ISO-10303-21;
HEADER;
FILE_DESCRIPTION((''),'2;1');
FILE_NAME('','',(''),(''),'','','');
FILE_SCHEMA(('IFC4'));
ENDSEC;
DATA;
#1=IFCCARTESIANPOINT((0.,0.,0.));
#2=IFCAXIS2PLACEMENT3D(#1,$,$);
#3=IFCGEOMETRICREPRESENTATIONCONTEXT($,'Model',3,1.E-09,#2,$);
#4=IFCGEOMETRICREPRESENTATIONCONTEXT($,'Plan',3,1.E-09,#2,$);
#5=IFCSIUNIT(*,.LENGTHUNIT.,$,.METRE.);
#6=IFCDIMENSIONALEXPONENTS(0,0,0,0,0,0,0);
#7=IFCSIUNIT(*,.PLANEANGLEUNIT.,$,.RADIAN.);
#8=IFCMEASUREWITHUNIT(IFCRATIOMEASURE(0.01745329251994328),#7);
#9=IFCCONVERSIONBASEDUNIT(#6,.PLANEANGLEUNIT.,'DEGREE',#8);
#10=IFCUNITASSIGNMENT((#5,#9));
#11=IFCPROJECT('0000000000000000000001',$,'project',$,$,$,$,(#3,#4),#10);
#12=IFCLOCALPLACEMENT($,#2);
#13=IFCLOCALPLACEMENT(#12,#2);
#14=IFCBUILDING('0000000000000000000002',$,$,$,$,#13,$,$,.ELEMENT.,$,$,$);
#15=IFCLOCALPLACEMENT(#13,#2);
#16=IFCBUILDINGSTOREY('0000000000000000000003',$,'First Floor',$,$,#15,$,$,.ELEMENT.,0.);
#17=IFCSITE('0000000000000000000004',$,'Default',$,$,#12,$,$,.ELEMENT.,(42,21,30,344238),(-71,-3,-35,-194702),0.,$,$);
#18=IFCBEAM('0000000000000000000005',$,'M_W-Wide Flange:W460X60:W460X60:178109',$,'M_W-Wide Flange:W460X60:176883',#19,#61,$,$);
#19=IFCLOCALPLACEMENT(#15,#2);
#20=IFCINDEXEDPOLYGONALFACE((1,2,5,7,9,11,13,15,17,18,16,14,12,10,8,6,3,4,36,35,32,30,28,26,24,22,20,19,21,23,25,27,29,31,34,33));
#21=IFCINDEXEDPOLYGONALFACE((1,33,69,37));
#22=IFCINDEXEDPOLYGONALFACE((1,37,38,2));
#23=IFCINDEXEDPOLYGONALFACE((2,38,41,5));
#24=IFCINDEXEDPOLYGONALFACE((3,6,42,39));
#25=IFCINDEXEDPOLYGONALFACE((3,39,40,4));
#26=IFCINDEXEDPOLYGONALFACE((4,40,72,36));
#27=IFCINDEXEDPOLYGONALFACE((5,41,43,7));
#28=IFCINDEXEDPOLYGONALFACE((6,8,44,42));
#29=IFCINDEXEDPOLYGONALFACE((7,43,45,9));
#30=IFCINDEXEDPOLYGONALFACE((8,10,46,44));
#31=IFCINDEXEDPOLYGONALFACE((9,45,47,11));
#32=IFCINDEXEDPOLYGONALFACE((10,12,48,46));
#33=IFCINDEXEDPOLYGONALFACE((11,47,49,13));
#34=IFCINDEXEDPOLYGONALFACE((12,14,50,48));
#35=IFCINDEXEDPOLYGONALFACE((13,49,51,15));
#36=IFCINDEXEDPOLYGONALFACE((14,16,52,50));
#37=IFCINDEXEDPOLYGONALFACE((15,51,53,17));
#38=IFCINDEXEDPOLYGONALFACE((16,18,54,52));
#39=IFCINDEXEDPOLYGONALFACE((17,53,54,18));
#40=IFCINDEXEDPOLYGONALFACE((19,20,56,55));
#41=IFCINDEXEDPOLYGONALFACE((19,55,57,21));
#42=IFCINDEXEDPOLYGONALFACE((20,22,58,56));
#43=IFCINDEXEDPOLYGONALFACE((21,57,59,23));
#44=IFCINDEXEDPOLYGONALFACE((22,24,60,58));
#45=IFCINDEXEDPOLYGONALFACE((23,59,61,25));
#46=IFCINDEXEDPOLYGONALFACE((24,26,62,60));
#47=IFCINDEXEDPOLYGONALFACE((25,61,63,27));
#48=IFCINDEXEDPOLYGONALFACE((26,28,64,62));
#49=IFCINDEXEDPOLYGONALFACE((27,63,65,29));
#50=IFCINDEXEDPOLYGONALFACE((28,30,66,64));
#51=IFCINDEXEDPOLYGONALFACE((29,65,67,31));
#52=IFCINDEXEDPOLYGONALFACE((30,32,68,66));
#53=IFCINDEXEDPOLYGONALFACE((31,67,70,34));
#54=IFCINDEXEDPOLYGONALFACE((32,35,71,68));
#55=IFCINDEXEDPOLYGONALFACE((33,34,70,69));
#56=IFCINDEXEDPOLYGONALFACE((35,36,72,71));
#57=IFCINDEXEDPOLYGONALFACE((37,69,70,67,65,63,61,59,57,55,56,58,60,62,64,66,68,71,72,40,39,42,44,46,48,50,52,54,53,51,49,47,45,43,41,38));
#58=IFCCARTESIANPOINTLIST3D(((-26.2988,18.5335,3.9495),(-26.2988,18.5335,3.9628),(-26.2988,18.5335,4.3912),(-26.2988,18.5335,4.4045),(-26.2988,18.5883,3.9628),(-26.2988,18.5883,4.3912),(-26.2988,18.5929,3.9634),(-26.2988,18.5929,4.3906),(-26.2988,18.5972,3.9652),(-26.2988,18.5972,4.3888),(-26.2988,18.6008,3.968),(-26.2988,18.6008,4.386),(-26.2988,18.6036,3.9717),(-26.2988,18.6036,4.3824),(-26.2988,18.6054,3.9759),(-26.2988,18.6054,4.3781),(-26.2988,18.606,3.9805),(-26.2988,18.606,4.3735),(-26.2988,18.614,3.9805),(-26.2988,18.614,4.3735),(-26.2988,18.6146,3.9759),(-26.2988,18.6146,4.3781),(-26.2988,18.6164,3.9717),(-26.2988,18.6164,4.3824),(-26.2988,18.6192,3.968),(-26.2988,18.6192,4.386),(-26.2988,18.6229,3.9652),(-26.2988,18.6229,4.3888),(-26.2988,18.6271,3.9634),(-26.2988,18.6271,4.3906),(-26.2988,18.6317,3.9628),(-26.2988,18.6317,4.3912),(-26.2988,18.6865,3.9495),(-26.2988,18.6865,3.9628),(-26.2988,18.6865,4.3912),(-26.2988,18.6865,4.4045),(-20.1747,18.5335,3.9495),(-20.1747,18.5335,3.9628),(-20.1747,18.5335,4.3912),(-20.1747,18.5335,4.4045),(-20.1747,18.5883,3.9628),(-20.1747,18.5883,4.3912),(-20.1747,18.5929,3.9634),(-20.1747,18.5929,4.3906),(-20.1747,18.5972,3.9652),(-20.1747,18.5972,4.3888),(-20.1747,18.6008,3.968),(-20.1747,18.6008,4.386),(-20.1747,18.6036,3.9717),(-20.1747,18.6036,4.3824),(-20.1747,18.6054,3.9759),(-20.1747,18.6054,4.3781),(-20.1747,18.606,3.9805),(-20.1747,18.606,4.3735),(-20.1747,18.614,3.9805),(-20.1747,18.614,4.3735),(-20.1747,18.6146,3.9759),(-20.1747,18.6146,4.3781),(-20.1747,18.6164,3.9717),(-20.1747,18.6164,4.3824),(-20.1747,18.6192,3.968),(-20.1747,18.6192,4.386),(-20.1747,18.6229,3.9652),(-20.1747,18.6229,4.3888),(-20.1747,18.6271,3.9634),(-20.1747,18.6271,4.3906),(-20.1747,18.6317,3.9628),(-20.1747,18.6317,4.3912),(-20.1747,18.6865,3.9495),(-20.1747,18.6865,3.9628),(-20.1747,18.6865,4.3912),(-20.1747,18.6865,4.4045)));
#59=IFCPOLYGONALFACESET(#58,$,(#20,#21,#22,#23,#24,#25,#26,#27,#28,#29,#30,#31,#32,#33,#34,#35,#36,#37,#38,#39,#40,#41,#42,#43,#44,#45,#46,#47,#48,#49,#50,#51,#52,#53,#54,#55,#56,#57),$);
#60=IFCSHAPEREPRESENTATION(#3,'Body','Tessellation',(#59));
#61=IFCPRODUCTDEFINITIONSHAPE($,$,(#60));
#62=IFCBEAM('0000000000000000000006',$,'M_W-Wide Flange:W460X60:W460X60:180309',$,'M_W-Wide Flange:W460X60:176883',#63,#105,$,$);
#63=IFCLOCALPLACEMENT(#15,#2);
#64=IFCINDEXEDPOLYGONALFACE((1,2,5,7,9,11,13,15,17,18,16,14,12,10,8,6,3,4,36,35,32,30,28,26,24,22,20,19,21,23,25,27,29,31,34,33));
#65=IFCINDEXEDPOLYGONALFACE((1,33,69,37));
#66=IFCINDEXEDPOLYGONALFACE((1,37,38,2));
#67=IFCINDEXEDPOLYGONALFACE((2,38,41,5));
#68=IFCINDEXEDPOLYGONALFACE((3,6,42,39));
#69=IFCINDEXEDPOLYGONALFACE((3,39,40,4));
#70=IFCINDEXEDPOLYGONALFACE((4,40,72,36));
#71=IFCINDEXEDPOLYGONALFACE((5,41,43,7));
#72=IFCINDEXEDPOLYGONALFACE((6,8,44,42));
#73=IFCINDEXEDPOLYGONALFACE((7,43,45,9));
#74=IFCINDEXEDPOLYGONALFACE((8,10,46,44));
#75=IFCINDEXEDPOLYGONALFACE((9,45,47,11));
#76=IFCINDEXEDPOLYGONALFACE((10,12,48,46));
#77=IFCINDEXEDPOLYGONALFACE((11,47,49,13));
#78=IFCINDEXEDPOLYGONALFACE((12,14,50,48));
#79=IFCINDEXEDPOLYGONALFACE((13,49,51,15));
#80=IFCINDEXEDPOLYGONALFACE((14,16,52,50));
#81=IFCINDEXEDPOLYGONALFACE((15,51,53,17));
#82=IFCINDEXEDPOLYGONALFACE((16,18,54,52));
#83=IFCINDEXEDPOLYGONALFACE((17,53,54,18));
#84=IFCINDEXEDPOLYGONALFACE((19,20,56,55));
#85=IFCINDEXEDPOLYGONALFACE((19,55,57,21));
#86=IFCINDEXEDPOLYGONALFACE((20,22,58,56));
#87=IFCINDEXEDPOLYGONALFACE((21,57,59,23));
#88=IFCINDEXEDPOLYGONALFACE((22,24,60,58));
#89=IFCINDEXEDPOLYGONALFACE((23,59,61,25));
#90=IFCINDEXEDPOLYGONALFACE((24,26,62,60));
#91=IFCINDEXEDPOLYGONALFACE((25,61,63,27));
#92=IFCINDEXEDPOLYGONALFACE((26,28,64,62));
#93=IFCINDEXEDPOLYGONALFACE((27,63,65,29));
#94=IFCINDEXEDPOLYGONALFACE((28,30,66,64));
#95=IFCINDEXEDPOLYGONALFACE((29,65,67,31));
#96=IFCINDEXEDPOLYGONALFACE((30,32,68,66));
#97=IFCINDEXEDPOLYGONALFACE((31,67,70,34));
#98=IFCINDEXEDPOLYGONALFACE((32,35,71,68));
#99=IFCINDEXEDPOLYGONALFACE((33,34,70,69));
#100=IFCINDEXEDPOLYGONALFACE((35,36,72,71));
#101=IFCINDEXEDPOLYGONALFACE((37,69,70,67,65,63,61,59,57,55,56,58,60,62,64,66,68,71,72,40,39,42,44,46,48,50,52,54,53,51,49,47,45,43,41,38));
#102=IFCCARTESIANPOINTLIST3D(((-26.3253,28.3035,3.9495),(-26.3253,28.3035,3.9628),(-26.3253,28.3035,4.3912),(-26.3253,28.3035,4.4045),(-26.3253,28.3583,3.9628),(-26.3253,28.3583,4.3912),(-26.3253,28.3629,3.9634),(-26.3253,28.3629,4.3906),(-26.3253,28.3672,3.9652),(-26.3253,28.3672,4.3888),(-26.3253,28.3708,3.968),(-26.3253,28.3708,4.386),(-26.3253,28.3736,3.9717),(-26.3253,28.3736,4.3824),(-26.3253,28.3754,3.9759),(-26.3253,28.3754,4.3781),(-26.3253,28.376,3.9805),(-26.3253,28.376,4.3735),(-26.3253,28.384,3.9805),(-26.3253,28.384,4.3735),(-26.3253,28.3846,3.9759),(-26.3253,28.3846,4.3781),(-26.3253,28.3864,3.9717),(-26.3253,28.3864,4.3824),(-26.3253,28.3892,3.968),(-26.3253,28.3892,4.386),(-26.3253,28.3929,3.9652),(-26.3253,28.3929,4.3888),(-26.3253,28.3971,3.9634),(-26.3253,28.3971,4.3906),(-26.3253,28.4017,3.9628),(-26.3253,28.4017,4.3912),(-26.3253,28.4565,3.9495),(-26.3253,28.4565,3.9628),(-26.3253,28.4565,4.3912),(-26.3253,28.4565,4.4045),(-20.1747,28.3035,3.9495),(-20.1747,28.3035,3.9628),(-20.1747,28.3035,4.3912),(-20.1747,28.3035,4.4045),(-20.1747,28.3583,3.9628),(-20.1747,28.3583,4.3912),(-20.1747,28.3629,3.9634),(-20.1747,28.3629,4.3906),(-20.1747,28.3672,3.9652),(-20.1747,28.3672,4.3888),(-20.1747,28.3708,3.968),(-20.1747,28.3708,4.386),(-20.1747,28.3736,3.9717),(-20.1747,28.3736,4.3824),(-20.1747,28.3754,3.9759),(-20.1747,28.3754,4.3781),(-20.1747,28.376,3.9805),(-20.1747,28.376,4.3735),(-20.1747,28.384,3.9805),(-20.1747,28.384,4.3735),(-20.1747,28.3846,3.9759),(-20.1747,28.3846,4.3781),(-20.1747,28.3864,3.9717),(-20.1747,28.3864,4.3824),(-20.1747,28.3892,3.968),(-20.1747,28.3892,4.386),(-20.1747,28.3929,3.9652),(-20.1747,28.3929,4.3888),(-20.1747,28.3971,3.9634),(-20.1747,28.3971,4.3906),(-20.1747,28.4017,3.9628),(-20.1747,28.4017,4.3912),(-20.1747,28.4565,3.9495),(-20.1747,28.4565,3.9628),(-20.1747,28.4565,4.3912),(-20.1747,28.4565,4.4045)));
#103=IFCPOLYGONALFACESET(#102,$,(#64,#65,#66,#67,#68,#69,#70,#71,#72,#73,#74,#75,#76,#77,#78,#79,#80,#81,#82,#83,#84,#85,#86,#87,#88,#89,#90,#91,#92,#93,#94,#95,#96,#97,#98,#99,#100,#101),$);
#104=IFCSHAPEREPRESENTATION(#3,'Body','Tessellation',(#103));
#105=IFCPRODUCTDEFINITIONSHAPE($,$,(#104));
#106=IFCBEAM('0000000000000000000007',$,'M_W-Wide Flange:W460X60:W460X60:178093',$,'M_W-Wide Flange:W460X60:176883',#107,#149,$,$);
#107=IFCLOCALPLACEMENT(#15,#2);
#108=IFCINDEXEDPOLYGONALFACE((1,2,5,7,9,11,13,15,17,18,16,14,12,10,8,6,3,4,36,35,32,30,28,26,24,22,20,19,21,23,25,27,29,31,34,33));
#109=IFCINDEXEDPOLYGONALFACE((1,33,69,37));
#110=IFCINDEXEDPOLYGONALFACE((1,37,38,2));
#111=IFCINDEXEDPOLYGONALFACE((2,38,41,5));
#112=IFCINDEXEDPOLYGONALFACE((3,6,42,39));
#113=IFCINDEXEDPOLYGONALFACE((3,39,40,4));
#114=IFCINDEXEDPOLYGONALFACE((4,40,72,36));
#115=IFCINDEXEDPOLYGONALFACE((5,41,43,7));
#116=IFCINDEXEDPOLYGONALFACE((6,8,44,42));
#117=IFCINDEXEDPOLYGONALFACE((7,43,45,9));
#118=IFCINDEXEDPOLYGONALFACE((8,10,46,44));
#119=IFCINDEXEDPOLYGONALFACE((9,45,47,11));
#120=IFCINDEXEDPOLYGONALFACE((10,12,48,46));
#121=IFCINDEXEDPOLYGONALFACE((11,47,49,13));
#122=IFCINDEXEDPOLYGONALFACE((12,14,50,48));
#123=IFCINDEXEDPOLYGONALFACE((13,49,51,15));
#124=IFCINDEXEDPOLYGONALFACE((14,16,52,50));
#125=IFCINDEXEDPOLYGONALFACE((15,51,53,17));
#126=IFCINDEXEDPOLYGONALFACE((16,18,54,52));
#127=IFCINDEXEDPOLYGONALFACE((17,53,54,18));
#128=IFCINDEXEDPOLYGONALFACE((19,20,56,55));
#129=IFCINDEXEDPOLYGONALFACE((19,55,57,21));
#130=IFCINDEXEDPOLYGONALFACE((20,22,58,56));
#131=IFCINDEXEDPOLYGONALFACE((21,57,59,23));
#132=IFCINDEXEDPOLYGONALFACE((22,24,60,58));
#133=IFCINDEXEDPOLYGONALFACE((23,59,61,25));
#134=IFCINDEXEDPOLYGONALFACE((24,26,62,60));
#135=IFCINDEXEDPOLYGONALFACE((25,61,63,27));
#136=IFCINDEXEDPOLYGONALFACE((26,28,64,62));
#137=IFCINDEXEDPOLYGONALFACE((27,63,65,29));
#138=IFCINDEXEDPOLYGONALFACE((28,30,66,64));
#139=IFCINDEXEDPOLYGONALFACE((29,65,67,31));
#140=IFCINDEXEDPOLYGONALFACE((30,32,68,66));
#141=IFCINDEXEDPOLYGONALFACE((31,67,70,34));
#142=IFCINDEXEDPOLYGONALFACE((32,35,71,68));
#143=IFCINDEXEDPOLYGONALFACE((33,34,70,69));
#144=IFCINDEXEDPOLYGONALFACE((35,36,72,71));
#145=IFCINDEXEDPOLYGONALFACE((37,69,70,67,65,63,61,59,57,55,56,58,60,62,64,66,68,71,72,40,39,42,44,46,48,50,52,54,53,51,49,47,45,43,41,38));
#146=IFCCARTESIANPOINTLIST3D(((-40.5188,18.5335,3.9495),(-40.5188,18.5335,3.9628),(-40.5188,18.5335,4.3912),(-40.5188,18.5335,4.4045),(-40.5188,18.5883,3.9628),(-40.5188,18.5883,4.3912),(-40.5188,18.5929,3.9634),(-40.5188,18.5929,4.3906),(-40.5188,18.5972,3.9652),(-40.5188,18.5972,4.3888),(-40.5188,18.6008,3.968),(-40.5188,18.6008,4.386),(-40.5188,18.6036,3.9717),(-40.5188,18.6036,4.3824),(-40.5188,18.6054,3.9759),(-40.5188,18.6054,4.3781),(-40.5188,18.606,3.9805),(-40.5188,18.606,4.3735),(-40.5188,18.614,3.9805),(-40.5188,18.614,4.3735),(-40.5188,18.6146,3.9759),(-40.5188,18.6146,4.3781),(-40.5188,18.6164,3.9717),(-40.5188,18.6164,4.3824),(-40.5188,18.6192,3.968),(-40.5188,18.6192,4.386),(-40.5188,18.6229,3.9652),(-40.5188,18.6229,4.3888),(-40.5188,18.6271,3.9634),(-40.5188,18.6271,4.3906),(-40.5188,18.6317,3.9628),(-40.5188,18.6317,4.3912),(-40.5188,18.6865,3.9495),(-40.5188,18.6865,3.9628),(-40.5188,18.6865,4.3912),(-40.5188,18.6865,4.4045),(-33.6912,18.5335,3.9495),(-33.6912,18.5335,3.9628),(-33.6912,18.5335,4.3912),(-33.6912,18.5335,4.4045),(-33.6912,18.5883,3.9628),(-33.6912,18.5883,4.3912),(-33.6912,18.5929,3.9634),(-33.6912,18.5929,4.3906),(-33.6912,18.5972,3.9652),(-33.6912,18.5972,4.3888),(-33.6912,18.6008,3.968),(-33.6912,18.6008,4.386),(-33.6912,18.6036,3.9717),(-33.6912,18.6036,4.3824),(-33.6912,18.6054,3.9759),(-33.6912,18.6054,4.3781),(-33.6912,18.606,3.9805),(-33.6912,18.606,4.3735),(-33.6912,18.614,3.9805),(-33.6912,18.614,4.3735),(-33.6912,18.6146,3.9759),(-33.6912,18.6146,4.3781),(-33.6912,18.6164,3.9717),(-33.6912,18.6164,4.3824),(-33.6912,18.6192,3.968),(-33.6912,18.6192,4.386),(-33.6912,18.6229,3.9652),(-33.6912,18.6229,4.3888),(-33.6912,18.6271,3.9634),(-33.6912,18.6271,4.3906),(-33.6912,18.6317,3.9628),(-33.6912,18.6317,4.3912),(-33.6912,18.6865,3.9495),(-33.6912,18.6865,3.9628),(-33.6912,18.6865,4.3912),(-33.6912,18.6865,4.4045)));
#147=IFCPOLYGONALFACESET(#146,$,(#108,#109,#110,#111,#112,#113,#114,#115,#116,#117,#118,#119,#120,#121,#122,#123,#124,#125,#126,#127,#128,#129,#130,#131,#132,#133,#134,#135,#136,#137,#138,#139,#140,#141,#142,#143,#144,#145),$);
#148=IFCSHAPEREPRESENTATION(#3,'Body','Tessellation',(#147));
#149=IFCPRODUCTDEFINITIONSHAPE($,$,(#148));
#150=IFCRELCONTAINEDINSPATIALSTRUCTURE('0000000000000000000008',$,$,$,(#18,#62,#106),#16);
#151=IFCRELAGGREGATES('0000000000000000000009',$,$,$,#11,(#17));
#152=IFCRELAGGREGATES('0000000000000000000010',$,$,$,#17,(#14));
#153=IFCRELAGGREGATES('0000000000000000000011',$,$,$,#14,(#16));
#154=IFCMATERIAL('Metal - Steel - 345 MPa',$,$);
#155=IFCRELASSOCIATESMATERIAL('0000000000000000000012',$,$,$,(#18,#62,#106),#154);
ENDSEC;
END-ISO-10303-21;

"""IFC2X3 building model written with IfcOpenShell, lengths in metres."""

from ifc_helpers import new_model, entity, si_unit, converted_unit, frame, frame_2d, origin, place, context, project, spatial, polyline, circle_curve, parameter, trimmed, segment, composite_curve, outline, extrude, material, element, save


model = new_model("IFC2X3")

# Units and contexts
model_context = context("Model", 3, precision=1e-09, world=origin())
plan_context = context("Plan", 3, precision=1e-09, world=origin())
ifc_project = project(units=[si_unit("LENGTHUNIT", "METRE"), converted_unit("PLANEANGLEUNIT", "DEGREE", entity("IfcRatioMeasure", 0.01745329251994328), si_unit("PLANEANGLEUNIT", "RADIAN"), dimensions=[0, 0, 0, 0, 0, 0, 0])], contexts=[model_context, plan_context])

# Site, building, storey
site_placement = place(None, origin())
site = spatial("IfcSite", under=ifc_project, at=site_placement, Name="Default", CompositionType="ELEMENT", RefLatitude=(42, 21, 30, 344238), RefLongitude=(-71, -3, -35, -194702), RefElevation=0.0)
building_placement = place(site_placement, origin())
building = spatial("IfcBuilding", under=site, at=building_placement, CompositionType="ELEMENT")
storey_placement = place(building_placement, origin())
storey = spatial("IfcBuildingStorey", under=building, at=storey_placement, Name="First Floor", CompositionType="ELEMENT", Elevation=0.0)

# Beams
ifc_material_1 = material(Name="Metal - Steel - 345 MPa")
beam_1_placement = place(storey_placement, frame((-26.4421, 18.61, 4.4045), z_axis=(0.0, 0.0, 1.0), x_axis=(0.0, -1.0, 0.0)))
element("IfcBeam", 1, at=beam_1_placement, inside=storey, material=ifc_material_1, Name="M_W-Wide Flange:W460X60:W460X60:178109", ObjectType="M_W-Wide Flange:W460X60:176883", context=model_context, shape_type="SweptSolid", body=[
    extrude(outline(composite_curve([segment(polyline([(-0.0765, -0.2142), (-0.0765, -0.2275)]), True, "CONTINUOUS"), segment(polyline([(-0.0765, -0.2275), (0.0765, -0.2275)]), True, "CONTINUOUS"), segment(polyline([(0.0765, -0.2275), (0.0765, -0.2142)]), True, "CONTINUOUS"), segment(polyline([(0.0765, -0.2142), (0.0217, -0.2142)]), True, "CONTINUOUS"), segment(trimmed(circle_curve(frame_2d((0.0217, -0.1965), x_axis=(0.0, -1.0)), 0.0177), [parameter(270.0)], [parameter(360.0)], True, "PARAMETER"), False, "CONTINUOUS"), segment(polyline([(0.004, -0.1965), (0.004, 0.1965)]), True, "CONTINUOUS"), segment(trimmed(circle_curve(frame_2d((0.0217, 0.1965), x_axis=(-1.0, 0.0)), 0.0177), [parameter(270.0)], [parameter(360.0)], True, "PARAMETER"), False, "CONTINUOUS"), segment(polyline([(0.0217, 0.2142), (0.0765, 0.2142)]), True, "CONTINUOUS"), segment(polyline([(0.0765, 0.2142), (0.0765, 0.2275)]), True, "CONTINUOUS"), segment(polyline([(0.0765, 0.2275), (-0.0765, 0.2275)]), True, "CONTINUOUS"), segment(polyline([(-0.0765, 0.2275), (-0.0765, 0.2142)]), True, "CONTINUOUS"), segment(polyline([(-0.0765, 0.2142), (-0.0217, 0.2142)]), True, "CONTINUOUS"), segment(trimmed(circle_curve(frame_2d((-0.0217, 0.1965), x_axis=(0.0, 1.0)), 0.0177), [parameter(270.0)], [parameter(360.0)], True, "PARAMETER"), False, "CONTINUOUS"), segment(polyline([(-0.004, 0.1965), (-0.004, -0.1965)]), True, "CONTINUOUS"), segment(trimmed(circle_curve(frame_2d((-0.0217, -0.1965), x_axis=(1.0, 0.0)), 0.0177), [parameter(270.0)], [parameter(0.0)], True, "PARAMETER"), False, "CONTINUOUS"), segment(polyline([(-0.0217, -0.2142), (-0.0765, -0.2142)]), True, "CONTINUOUS")], self_intersect=False)), frame((0.0, 0.1433, -0.2275), z_axis=(0.0, -1.0, 0.0), x_axis=(1.0, 0.0, 0.0)), (0.0, 0.0, -1.0), 6.1241),
])
beam_2_placement = place(storey_placement, frame((-20.0579, 28.38, 4.4045), z_axis=(0.0, 0.0, 1.0), x_axis=(0.0, 1.0, 0.0)))
element("IfcBeam", 2, at=beam_2_placement, inside=storey, material=ifc_material_1, Name="M_W-Wide Flange:W460X60:W460X60:180309", ObjectType="M_W-Wide Flange:W460X60:176883", context=model_context, shape_type="SweptSolid", body=[
    extrude(outline(composite_curve([segment(polyline([(0.2142, -0.0765), (0.2275, -0.0765)]), True, "CONTINUOUS"), segment(polyline([(0.2275, -0.0765), (0.2275, 0.0765)]), True, "CONTINUOUS"), segment(polyline([(0.2275, 0.0765), (0.2142, 0.0765)]), True, "CONTINUOUS"), segment(polyline([(0.2142, 0.0765), (0.2142, 0.0217)]), True, "CONTINUOUS"), segment(trimmed(circle_curve(frame_2d((0.1965, 0.0217), x_axis=(1.0, 0.0)), 0.0177), [parameter(270.0)], [parameter(360.0)], True, "PARAMETER"), False, "CONTINUOUS"), segment(polyline([(0.1965, 0.004), (-0.1965, 0.004)]), True, "CONTINUOUS"), segment(trimmed(circle_curve(frame_2d((-0.1965, 0.0217), x_axis=(0.0, -1.0)), 0.0177), [parameter(270.0)], [parameter(360.0)], True, "PARAMETER"), False, "CONTINUOUS"), segment(polyline([(-0.2142, 0.0217), (-0.2142, 0.0765)]), True, "CONTINUOUS"), segment(polyline([(-0.2142, 0.0765), (-0.2275, 0.0765)]), True, "CONTINUOUS"), segment(polyline([(-0.2275, 0.0765), (-0.2275, -0.0765)]), True, "CONTINUOUS"), segment(polyline([(-0.2275, -0.0765), (-0.2142, -0.0765)]), True, "CONTINUOUS"), segment(polyline([(-0.2142, -0.0765), (-0.2142, -0.0217)]), True, "CONTINUOUS"), segment(trimmed(circle_curve(frame_2d((-0.1965, -0.0217), x_axis=(-1.0, 0.0)), 0.0177), [parameter(270.0)], [parameter(360.0)], True, "PARAMETER"), False, "CONTINUOUS"), segment(polyline([(-0.1965, -0.004), (0.1965, -0.004)]), True, "CONTINUOUS"), segment(trimmed(circle_curve(frame_2d((0.1965, -0.0217), x_axis=(0.0, 1.0)), 0.0177), [parameter(270.0)], [parameter(0.0)], True, "PARAMETER"), False, "CONTINUOUS"), segment(polyline([(0.2142, -0.0217), (0.2142, -0.0765)]), True, "CONTINUOUS")], self_intersect=False)), frame((0.0, 6.2674, -0.2275), z_axis=(0.0, -1.0, 0.0), x_axis=(0.0, 0.0, -1.0)), (0.0, 0.0, 1.0), 6.1506),
])
beam_3_placement = place(storey_placement, frame((-40.6619, 18.61, 4.4045), z_axis=(0.0, 0.0, 1.0), x_axis=(0.0, -1.0, 0.0)))
element("IfcBeam", 3, at=beam_3_placement, inside=storey, material=ifc_material_1, Name="M_W-Wide Flange:W460X60:W460X60:178093", ObjectType="M_W-Wide Flange:W460X60:176883", context=model_context, shape_type="SweptSolid", body=[
    extrude(outline(composite_curve([segment(polyline([(-0.0765, -0.2142), (-0.0765, -0.2275)]), True, "CONTINUOUS"), segment(polyline([(-0.0765, -0.2275), (0.0765, -0.2275)]), True, "CONTINUOUS"), segment(polyline([(0.0765, -0.2275), (0.0765, -0.2142)]), True, "CONTINUOUS"), segment(polyline([(0.0765, -0.2142), (0.0217, -0.2142)]), True, "CONTINUOUS"), segment(trimmed(circle_curve(frame_2d((0.0217, -0.1965), x_axis=(0.0, -1.0)), 0.0177), [parameter(270.0)], [parameter(360.0)], True, "PARAMETER"), False, "CONTINUOUS"), segment(polyline([(0.004, -0.1965), (0.004, 0.1965)]), True, "CONTINUOUS"), segment(trimmed(circle_curve(frame_2d((0.0217, 0.1965), x_axis=(-1.0, 0.0)), 0.0177), [parameter(270.0)], [parameter(360.0)], True, "PARAMETER"), False, "CONTINUOUS"), segment(polyline([(0.0217, 0.2142), (0.0765, 0.2142)]), True, "CONTINUOUS"), segment(polyline([(0.0765, 0.2142), (0.0765, 0.2275)]), True, "CONTINUOUS"), segment(polyline([(0.0765, 0.2275), (-0.0765, 0.2275)]), True, "CONTINUOUS"), segment(polyline([(-0.0765, 0.2275), (-0.0765, 0.2142)]), True, "CONTINUOUS"), segment(polyline([(-0.0765, 0.2142), (-0.0217, 0.2142)]), True, "CONTINUOUS"), segment(trimmed(circle_curve(frame_2d((-0.0217, 0.1965), x_axis=(0.0, 1.0)), 0.0177), [parameter(270.0)], [parameter(360.0)], True, "PARAMETER"), False, "CONTINUOUS"), segment(polyline([(-0.004, 0.1965), (-0.004, -0.1965)]), True, "CONTINUOUS"), segment(trimmed(circle_curve(frame_2d((-0.0217, -0.1965), x_axis=(1.0, 0.0)), 0.0177), [parameter(270.0)], [parameter(0.0)], True, "PARAMETER"), False, "CONTINUOUS"), segment(polyline([(-0.0217, -0.2142), (-0.0765, -0.2142)]), True, "CONTINUOUS")], self_intersect=False)), frame((0.0, 0.1431, -0.2275), z_axis=(0.0, -1.0, 0.0), x_axis=(1.0, 0.0, 0.0)), (0.0, 0.0, -1.0), 6.8276),
])

save(model, "model.ifc")
